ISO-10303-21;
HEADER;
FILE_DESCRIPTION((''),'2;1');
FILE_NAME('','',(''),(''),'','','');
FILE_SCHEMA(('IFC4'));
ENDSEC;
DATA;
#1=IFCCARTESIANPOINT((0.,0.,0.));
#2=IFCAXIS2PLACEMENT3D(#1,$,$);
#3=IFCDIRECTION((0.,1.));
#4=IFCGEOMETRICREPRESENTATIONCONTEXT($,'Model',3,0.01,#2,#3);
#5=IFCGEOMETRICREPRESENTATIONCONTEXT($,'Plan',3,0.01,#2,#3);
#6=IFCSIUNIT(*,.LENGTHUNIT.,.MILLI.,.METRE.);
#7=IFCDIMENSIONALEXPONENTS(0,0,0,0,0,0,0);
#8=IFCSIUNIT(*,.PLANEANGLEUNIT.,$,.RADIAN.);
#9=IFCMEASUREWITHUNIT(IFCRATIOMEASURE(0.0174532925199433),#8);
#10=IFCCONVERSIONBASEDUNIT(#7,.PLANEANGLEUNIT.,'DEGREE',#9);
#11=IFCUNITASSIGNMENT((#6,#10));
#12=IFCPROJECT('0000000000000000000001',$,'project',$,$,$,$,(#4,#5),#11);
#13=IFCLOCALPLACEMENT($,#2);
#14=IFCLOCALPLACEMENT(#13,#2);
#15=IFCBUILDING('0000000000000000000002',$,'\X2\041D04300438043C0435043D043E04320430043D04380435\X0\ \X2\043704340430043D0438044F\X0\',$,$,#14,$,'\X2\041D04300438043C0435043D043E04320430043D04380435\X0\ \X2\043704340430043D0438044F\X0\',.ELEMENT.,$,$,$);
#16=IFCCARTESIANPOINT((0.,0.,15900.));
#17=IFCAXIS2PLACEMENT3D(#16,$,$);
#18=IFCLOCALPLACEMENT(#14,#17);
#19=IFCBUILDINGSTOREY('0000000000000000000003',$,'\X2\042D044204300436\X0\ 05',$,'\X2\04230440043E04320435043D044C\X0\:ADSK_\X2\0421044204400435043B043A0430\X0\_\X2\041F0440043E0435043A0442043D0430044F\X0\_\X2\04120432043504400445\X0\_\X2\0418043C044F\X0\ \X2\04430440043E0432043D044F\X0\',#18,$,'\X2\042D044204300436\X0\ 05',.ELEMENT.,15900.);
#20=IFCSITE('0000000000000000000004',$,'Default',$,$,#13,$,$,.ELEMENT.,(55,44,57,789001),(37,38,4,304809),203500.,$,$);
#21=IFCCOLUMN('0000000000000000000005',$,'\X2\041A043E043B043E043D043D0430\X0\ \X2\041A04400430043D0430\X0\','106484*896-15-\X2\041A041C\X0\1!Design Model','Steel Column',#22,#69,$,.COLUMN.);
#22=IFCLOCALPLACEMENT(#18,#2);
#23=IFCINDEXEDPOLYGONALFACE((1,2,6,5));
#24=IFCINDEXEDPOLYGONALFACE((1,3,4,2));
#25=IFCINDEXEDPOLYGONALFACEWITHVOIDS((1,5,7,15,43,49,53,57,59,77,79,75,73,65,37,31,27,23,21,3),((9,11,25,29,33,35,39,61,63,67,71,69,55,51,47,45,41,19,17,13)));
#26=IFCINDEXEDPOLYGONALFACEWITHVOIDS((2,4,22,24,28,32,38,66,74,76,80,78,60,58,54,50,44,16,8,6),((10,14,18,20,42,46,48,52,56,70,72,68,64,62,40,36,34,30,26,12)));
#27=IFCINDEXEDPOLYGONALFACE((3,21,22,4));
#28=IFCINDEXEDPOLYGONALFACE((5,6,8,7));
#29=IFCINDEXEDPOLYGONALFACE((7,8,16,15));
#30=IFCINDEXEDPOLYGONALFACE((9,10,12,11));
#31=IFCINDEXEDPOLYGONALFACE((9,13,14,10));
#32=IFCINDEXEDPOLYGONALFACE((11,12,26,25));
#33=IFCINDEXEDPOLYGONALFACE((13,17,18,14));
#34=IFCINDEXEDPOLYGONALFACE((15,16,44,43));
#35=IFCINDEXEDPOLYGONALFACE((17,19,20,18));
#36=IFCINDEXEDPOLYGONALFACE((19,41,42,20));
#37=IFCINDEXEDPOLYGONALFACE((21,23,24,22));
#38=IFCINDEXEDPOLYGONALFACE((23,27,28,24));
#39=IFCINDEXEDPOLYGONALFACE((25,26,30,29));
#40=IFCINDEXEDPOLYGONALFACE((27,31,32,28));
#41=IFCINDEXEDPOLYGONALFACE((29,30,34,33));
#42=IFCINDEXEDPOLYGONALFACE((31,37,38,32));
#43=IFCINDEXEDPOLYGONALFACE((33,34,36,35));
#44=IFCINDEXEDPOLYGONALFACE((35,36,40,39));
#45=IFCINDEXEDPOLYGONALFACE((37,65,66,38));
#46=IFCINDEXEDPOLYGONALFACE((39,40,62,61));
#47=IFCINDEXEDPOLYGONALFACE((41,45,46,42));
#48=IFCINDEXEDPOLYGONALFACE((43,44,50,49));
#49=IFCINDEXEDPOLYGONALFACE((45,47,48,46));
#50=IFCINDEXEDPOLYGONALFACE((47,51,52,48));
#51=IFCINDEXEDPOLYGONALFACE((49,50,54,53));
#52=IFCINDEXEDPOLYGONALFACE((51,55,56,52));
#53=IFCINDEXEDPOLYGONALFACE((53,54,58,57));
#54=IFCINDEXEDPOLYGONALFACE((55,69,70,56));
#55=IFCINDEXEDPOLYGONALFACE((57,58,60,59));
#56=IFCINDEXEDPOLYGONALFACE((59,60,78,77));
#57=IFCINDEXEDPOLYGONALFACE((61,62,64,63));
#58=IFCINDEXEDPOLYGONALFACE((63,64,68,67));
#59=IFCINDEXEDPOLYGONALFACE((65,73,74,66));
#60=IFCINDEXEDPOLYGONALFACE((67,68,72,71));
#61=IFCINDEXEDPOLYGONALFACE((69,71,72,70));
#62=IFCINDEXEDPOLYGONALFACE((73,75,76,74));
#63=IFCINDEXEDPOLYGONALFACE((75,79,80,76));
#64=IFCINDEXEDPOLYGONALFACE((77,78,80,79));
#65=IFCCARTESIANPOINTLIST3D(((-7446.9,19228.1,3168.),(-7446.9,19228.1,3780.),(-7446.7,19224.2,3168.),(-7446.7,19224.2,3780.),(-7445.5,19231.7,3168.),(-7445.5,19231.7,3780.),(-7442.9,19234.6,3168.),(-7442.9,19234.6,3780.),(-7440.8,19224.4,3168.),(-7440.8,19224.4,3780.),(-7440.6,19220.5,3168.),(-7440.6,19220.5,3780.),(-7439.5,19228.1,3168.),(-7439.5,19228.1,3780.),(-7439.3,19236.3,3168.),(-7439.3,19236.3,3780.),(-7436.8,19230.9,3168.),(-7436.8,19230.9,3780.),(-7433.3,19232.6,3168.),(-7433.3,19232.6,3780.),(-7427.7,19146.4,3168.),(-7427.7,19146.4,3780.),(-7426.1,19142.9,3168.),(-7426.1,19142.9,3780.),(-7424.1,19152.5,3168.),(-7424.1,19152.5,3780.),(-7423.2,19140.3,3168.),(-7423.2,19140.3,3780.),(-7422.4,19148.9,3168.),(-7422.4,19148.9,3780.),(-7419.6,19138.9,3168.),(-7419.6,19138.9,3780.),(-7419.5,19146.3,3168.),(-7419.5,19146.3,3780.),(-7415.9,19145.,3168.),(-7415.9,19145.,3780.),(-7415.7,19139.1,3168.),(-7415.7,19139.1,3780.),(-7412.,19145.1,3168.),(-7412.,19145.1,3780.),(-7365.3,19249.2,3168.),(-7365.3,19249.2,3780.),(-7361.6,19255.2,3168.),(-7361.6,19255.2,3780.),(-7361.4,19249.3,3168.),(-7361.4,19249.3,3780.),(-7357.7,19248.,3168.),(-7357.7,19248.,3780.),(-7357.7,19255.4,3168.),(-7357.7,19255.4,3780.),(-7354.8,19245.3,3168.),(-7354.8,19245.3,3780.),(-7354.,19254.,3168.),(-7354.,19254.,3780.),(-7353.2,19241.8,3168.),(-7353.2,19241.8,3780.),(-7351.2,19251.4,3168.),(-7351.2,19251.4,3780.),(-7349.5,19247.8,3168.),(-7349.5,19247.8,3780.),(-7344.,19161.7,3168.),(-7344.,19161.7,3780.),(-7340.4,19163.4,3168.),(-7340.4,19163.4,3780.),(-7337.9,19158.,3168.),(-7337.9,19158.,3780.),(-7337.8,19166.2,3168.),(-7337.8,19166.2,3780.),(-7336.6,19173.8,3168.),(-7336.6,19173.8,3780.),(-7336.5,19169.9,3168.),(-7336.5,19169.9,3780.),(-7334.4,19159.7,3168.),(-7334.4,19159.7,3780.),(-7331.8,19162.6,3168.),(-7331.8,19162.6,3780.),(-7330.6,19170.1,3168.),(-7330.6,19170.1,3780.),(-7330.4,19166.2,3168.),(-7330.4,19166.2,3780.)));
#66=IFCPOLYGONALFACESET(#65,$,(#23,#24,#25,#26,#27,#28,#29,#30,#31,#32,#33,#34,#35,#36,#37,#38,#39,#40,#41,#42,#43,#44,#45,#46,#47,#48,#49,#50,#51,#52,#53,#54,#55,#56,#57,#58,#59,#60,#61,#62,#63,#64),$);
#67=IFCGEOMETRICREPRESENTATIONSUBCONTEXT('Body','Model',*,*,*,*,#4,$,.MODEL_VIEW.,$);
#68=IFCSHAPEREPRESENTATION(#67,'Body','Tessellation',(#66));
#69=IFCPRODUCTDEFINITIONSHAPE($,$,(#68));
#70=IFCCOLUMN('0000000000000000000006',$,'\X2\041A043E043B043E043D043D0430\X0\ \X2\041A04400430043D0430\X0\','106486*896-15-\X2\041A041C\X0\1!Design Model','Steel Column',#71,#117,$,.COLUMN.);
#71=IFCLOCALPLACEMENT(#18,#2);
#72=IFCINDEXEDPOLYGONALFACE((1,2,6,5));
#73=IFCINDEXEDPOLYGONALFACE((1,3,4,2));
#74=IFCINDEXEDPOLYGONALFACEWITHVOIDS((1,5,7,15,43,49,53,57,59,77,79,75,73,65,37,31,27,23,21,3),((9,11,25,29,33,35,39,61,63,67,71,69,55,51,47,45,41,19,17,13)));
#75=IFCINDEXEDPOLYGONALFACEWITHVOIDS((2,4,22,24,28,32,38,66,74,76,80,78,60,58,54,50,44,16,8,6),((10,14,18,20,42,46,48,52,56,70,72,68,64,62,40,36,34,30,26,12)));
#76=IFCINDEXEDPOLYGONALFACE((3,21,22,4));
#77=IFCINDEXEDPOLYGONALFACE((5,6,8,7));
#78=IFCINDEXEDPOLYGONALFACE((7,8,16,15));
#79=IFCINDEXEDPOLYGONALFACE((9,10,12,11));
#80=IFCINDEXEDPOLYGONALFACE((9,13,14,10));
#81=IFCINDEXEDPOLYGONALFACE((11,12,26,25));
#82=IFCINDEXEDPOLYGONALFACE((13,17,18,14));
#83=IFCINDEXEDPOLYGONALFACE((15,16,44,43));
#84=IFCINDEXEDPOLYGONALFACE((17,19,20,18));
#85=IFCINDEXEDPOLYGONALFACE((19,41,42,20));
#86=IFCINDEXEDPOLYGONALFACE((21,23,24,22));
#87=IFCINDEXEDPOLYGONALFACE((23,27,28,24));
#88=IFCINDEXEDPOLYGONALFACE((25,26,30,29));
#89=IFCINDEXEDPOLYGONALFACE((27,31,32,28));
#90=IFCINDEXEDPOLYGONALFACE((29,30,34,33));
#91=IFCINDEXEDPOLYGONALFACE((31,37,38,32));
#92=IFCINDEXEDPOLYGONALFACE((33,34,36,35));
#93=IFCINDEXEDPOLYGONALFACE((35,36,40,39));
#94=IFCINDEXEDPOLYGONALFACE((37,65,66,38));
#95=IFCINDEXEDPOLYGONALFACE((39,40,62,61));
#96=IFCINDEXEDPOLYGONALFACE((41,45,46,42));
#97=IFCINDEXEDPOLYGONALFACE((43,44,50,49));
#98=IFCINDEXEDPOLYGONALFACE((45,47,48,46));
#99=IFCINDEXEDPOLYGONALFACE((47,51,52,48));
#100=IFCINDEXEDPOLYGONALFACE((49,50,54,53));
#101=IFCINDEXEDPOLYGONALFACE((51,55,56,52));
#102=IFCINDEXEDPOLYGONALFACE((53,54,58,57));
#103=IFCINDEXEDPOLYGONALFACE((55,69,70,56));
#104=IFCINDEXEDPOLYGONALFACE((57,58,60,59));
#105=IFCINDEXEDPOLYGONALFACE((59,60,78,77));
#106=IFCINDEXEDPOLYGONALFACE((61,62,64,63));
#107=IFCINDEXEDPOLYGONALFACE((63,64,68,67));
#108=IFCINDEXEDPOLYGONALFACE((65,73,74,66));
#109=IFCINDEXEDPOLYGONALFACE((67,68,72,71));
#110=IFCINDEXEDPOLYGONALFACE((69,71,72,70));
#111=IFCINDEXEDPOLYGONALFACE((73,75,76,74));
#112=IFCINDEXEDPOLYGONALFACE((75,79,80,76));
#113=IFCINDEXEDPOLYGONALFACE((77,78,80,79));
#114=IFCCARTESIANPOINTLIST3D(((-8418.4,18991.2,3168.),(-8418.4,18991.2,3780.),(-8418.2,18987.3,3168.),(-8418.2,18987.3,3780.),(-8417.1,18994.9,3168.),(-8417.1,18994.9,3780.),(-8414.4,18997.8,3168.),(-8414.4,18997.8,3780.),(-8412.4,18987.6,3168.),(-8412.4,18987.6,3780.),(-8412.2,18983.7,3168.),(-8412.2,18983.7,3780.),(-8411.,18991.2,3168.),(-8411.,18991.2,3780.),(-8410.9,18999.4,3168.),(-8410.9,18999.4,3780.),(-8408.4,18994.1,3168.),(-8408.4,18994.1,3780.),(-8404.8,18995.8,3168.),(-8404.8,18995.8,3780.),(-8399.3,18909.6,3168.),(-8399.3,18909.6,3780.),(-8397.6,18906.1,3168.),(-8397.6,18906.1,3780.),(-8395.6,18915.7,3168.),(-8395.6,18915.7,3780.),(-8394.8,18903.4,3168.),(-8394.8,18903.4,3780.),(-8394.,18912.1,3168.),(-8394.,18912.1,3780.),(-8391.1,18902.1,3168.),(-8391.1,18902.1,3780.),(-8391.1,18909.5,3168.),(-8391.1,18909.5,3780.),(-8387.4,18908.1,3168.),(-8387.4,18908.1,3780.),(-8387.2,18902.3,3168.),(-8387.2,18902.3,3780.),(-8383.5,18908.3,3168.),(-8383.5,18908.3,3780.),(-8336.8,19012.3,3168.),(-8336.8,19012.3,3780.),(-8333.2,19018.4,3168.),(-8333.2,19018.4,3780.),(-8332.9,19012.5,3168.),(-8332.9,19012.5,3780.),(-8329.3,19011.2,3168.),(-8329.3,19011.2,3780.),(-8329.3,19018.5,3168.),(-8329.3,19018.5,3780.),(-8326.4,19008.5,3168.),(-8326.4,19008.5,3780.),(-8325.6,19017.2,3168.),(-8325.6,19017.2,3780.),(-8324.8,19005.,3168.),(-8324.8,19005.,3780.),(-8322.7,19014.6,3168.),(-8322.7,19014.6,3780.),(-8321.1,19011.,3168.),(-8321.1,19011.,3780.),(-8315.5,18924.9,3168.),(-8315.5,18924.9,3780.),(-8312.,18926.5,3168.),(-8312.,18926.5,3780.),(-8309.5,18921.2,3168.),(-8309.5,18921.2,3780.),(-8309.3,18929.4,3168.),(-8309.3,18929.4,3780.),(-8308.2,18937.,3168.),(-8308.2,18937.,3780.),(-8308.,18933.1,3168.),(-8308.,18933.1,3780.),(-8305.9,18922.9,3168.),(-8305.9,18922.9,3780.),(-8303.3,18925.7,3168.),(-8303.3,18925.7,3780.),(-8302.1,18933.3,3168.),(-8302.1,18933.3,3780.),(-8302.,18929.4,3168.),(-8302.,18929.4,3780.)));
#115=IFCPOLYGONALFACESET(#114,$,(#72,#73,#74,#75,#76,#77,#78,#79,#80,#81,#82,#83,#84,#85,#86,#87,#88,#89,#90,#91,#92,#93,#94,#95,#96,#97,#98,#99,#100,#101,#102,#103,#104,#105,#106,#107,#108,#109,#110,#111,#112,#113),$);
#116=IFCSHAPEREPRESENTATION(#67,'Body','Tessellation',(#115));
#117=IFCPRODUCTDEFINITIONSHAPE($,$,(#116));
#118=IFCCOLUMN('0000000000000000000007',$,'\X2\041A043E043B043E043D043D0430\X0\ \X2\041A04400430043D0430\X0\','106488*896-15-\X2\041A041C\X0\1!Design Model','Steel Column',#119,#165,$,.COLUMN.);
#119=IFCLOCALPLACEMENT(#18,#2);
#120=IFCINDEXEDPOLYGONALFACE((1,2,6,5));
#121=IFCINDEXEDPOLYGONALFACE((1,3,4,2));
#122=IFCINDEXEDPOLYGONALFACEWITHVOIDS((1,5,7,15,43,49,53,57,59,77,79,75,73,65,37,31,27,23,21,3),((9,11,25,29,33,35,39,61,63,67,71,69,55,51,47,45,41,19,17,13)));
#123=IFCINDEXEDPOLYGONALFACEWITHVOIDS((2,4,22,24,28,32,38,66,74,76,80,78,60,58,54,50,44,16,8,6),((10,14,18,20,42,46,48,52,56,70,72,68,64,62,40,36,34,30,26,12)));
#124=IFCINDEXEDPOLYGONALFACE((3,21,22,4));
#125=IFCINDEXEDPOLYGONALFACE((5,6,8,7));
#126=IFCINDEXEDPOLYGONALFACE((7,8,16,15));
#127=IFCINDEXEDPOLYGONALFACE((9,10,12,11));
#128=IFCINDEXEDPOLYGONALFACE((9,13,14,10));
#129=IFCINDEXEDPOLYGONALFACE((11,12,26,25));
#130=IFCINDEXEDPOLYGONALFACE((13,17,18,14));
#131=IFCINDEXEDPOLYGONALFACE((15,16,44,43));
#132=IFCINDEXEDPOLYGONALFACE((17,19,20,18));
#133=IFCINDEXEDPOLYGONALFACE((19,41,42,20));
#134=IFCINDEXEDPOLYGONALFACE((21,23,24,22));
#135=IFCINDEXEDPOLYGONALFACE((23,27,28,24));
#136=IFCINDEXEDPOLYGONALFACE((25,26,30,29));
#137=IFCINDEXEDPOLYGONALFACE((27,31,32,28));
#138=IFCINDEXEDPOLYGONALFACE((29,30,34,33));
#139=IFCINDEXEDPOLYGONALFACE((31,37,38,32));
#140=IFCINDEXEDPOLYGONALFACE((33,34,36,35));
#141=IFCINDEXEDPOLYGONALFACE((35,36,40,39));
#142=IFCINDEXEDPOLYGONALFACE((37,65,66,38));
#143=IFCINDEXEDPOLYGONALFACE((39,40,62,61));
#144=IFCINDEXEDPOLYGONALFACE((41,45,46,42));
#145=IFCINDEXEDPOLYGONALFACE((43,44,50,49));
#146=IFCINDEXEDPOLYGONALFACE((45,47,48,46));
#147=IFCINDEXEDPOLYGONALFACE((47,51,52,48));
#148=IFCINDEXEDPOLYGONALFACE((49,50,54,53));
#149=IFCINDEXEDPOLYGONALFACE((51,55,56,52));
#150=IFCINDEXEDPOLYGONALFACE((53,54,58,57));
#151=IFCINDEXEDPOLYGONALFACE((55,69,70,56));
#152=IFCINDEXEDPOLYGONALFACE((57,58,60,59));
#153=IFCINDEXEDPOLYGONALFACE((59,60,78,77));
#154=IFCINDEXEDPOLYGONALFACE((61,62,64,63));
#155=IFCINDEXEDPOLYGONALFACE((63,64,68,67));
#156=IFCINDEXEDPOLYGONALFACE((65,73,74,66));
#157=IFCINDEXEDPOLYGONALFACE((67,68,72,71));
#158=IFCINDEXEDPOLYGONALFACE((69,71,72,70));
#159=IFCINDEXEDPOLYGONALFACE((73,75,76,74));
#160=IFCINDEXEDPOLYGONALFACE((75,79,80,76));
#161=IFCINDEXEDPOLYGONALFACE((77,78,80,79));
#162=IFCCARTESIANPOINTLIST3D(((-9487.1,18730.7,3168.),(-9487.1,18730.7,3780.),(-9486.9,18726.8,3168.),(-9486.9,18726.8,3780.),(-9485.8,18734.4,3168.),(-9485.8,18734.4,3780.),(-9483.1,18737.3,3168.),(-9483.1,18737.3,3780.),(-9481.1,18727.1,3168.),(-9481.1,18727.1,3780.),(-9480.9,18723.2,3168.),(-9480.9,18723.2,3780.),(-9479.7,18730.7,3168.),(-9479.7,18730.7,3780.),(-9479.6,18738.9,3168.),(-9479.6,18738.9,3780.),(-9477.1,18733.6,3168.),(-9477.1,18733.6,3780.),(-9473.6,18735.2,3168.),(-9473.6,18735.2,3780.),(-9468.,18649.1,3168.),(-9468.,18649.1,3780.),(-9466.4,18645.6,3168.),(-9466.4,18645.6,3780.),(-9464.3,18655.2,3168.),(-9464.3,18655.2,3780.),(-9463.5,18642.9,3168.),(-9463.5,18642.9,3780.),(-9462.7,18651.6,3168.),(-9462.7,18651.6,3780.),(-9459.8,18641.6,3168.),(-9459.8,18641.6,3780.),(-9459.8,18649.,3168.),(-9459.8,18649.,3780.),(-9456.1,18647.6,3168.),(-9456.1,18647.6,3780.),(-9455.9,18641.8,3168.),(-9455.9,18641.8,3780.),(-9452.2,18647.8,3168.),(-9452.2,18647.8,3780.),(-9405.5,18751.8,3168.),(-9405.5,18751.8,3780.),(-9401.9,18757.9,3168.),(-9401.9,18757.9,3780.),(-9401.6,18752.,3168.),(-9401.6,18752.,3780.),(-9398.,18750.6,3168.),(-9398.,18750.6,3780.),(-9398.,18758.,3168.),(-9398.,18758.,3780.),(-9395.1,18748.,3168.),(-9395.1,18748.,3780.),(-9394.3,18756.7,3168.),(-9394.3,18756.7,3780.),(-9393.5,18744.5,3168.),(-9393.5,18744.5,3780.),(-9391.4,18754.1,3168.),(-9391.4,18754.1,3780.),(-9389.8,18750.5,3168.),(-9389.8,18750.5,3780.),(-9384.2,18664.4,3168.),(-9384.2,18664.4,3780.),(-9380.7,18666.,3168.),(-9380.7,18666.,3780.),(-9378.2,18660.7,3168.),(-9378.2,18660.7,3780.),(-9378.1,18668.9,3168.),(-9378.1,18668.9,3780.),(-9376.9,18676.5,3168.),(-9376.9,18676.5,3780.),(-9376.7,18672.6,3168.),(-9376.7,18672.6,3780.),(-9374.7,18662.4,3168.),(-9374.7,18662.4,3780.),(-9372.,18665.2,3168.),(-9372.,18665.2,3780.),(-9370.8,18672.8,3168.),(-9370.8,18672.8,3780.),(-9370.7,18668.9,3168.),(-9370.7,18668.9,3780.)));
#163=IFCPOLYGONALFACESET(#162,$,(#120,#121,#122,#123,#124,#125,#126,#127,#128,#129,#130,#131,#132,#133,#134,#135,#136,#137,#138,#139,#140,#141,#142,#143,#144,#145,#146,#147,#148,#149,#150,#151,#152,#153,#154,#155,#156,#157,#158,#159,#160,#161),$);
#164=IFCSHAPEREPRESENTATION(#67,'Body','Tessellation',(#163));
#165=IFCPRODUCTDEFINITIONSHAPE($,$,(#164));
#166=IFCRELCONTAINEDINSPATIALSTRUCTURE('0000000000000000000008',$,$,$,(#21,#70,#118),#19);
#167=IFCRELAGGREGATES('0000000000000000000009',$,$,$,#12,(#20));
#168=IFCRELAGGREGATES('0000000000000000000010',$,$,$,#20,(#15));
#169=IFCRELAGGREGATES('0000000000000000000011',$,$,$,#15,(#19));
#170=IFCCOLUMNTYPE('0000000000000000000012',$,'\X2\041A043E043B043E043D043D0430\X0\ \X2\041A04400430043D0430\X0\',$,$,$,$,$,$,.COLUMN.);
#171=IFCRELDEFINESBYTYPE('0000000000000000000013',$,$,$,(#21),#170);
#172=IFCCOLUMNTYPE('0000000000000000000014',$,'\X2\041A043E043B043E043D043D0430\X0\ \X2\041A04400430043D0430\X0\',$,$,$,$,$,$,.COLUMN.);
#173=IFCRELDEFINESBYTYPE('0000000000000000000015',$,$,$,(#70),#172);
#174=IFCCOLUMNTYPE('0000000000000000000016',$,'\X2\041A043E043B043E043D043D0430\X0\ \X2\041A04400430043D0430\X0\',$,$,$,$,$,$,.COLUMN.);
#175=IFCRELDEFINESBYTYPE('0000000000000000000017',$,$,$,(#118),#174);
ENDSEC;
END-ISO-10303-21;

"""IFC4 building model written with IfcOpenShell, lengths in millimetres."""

from ifc_helpers import new_model, entity, si_unit, converted_unit, direction, frame, origin, place, context, subcontext, project, spatial, indexed_curve, outline, extrude, type_object, element, save


model = new_model("IFC4")

# Units and contexts
model_context = context("Model", 3, precision=0.01, world=origin(), true_north=direction((0.0, 1.0)))
plan_context = context("Plan", 3, precision=0.01, world=origin(), true_north=direction((0.0, 1.0)))
body_context = subcontext(model_context, "Body", "Model", "MODEL_VIEW")
ifc_project = project(units=[si_unit("LENGTHUNIT", "METRE", prefix="MILLI"), converted_unit("PLANEANGLEUNIT", "DEGREE", entity("IfcRatioMeasure", 0.0174532925199433), si_unit("PLANEANGLEUNIT", "RADIAN"), dimensions=[0, 0, 0, 0, 0, 0, 0])], contexts=[model_context, plan_context])

# Site, building, storey
site_placement = place(None, origin())
site = spatial("IfcSite", under=ifc_project, at=site_placement, Name="Default", CompositionType="ELEMENT", RefLatitude=(55, 44, 57, 789001), RefLongitude=(37, 38, 4, 304809), RefElevation=203500.0)
building_placement = place(site_placement, origin())
building = spatial("IfcBuilding", under=site, at=building_placement, Name="Наименование здания", LongName="Наименование здания", CompositionType="ELEMENT")
storey_placement = place(building_placement, frame((0.0, 0.0, 15900.0)))
storey = spatial("IfcBuildingStorey", under=building, at=storey_placement, Name="Этаж 05", ObjectType="Уровень:ADSK_Стрелка_Проектная_Вверх_Имя уровня", LongName="Этаж 05", CompositionType="ELEMENT", Elevation=15900.0)

# Columns
column_type_1 = type_object("IfcColumnType", Name="Колонна Крана", PredefinedType="COLUMN")
column_1_placement = place(storey_placement, origin())
element("IfcColumn", 1, at=column_1_placement, inside=storey, type_object=column_type_1, Name="Колонна Крана", Description="106484*896-15-КМ1!Design Model", ObjectType="Steel Column", PredefinedType="COLUMN", context=body_context, shape_type="SweptSolid", body=[
    extrude(outline(indexed_curve([(29.5, -56.8), (33.4, -56.8), (37.0, -55.3), (39.7, -52.6), (41.2, -49.0), (56.8, 29.5), (56.8, 33.4), (55.3, 37.0), (52.6, 39.7), (49.0, 41.2), (-29.5, 56.8), (-33.4, 56.8), (-37.0, 55.3), (-39.7, 52.6), (-41.2, 49.0), (-56.8, -29.5), (-56.8, -33.4), (-55.3, -37.0), (-52.6, -39.7), (-49.0, -41.2), (29.5, -56.8)], self_intersect=False), holes=[indexed_curve([(-43.1, -37.3), (-46.7, -35.8), (-49.5, -33.1), (-51.0, -29.5), (-51.0, -25.5), (-37.3, 43.1), (-35.8, 46.7), (-33.1, 49.5), (-29.5, 51.0), (-25.5, 51.0), (43.1, 37.3), (46.7, 35.8), (49.5, 33.1), (51.0, 29.5), (51.0, 25.5), (37.3, -43.1), (35.8, -46.7), (33.1, -49.5), (29.5, -51.0), (25.5, -51.0), (-43.1, -37.3)], self_intersect=False)]), frame((-7388.6, 19197.1, 3168.0), z_axis=(0.0, 0.0, 1.0), x_axis=(0.906681, 0.421816, 0.0)), (0.0, 0.0, 1.0), 612.0),
])
column_type_2 = type_object("IfcColumnType", Name="Колонна Крана", PredefinedType="COLUMN")
column_2_placement = place(storey_placement, origin())
element("IfcColumn", 2, at=column_2_placement, inside=storey, type_object=column_type_2, Name="Колонна Крана", Description="106486*896-15-КМ1!Design Model", ObjectType="Steel Column", PredefinedType="COLUMN", context=body_context, shape_type="SweptSolid", body=[
    extrude(outline(indexed_curve([(29.5, -56.8), (33.4, -56.8), (37.0, -55.3), (39.7, -52.6), (41.2, -49.0), (56.8, 29.5), (56.8, 33.4), (55.3, 37.0), (52.6, 39.7), (49.0, 41.2), (-29.5, 56.8), (-33.4, 56.8), (-37.0, 55.3), (-39.7, 52.6), (-41.2, 49.0), (-56.8, -29.5), (-56.8, -33.4), (-55.3, -37.0), (-52.6, -39.7), (-49.0, -41.2), (29.5, -56.8)], self_intersect=False), holes=[indexed_curve([(-43.1, -37.3), (-46.7, -35.8), (-49.5, -33.1), (-51.0, -29.5), (-51.0, -25.5), (-37.3, 43.1), (-35.8, 46.7), (-33.1, 49.5), (-29.5, 51.0), (-25.5, 51.0), (43.1, 37.3), (46.7, 35.8), (49.5, 33.1), (51.0, 29.5), (51.0, 25.5), (37.3, -43.1), (35.8, -46.7), (33.1, -49.5), (29.5, -51.0), (25.5, -51.0), (-43.1, -37.3)], self_intersect=False)]), frame((-8360.2, 18960.3, 3168.0), z_axis=(0.0, 0.0, 1.0), x_axis=(0.906681, 0.421816, 0.0)), (0.0, 0.0, 1.0), 612.0),
])
column_type_3 = type_object("IfcColumnType", Name="Колонна Крана", PredefinedType="COLUMN")
column_3_placement = place(storey_placement, origin())
element("IfcColumn", 3, at=column_3_placement, inside=storey, type_object=column_type_3, Name="Колонна Крана", Description="106488*896-15-КМ1!Design Model", ObjectType="Steel Column", PredefinedType="COLUMN", context=body_context, shape_type="SweptSolid", body=[
    extrude(outline(indexed_curve([(29.5, -56.8), (33.4, -56.8), (37.0, -55.3), (39.7, -52.6), (41.2, -49.0), (56.8, 29.5), (56.8, 33.4), (55.3, 37.0), (52.6, 39.7), (49.0, 41.2), (-29.5, 56.8), (-33.4, 56.8), (-37.0, 55.3), (-39.7, 52.6), (-41.2, 49.0), (-56.8, -29.5), (-56.8, -33.4), (-55.3, -37.0), (-52.6, -39.7), (-49.0, -41.2), (29.5, -56.8)], self_intersect=False), holes=[indexed_curve([(-43.1, -37.3), (-46.7, -35.8), (-49.5, -33.1), (-51.0, -29.5), (-51.0, -25.5), (-37.3, 43.1), (-35.8, 46.7), (-33.1, 49.5), (-29.5, 51.0), (-25.5, 51.0), (43.1, 37.3), (46.7, 35.8), (49.5, 33.1), (51.0, 29.5), (51.0, 25.5), (37.3, -43.1), (35.8, -46.7), (33.1, -49.5), (29.5, -51.0), (25.5, -51.0), (-43.1, -37.3)], self_intersect=False)]), frame((-9428.9, 18699.8, 3168.0), z_axis=(0.0, 0.0, 1.0), x_axis=(0.906681, 0.421816, 0.0)), (0.0, 0.0, 1.0), 612.0),
])

save(model, "model.ifc")
